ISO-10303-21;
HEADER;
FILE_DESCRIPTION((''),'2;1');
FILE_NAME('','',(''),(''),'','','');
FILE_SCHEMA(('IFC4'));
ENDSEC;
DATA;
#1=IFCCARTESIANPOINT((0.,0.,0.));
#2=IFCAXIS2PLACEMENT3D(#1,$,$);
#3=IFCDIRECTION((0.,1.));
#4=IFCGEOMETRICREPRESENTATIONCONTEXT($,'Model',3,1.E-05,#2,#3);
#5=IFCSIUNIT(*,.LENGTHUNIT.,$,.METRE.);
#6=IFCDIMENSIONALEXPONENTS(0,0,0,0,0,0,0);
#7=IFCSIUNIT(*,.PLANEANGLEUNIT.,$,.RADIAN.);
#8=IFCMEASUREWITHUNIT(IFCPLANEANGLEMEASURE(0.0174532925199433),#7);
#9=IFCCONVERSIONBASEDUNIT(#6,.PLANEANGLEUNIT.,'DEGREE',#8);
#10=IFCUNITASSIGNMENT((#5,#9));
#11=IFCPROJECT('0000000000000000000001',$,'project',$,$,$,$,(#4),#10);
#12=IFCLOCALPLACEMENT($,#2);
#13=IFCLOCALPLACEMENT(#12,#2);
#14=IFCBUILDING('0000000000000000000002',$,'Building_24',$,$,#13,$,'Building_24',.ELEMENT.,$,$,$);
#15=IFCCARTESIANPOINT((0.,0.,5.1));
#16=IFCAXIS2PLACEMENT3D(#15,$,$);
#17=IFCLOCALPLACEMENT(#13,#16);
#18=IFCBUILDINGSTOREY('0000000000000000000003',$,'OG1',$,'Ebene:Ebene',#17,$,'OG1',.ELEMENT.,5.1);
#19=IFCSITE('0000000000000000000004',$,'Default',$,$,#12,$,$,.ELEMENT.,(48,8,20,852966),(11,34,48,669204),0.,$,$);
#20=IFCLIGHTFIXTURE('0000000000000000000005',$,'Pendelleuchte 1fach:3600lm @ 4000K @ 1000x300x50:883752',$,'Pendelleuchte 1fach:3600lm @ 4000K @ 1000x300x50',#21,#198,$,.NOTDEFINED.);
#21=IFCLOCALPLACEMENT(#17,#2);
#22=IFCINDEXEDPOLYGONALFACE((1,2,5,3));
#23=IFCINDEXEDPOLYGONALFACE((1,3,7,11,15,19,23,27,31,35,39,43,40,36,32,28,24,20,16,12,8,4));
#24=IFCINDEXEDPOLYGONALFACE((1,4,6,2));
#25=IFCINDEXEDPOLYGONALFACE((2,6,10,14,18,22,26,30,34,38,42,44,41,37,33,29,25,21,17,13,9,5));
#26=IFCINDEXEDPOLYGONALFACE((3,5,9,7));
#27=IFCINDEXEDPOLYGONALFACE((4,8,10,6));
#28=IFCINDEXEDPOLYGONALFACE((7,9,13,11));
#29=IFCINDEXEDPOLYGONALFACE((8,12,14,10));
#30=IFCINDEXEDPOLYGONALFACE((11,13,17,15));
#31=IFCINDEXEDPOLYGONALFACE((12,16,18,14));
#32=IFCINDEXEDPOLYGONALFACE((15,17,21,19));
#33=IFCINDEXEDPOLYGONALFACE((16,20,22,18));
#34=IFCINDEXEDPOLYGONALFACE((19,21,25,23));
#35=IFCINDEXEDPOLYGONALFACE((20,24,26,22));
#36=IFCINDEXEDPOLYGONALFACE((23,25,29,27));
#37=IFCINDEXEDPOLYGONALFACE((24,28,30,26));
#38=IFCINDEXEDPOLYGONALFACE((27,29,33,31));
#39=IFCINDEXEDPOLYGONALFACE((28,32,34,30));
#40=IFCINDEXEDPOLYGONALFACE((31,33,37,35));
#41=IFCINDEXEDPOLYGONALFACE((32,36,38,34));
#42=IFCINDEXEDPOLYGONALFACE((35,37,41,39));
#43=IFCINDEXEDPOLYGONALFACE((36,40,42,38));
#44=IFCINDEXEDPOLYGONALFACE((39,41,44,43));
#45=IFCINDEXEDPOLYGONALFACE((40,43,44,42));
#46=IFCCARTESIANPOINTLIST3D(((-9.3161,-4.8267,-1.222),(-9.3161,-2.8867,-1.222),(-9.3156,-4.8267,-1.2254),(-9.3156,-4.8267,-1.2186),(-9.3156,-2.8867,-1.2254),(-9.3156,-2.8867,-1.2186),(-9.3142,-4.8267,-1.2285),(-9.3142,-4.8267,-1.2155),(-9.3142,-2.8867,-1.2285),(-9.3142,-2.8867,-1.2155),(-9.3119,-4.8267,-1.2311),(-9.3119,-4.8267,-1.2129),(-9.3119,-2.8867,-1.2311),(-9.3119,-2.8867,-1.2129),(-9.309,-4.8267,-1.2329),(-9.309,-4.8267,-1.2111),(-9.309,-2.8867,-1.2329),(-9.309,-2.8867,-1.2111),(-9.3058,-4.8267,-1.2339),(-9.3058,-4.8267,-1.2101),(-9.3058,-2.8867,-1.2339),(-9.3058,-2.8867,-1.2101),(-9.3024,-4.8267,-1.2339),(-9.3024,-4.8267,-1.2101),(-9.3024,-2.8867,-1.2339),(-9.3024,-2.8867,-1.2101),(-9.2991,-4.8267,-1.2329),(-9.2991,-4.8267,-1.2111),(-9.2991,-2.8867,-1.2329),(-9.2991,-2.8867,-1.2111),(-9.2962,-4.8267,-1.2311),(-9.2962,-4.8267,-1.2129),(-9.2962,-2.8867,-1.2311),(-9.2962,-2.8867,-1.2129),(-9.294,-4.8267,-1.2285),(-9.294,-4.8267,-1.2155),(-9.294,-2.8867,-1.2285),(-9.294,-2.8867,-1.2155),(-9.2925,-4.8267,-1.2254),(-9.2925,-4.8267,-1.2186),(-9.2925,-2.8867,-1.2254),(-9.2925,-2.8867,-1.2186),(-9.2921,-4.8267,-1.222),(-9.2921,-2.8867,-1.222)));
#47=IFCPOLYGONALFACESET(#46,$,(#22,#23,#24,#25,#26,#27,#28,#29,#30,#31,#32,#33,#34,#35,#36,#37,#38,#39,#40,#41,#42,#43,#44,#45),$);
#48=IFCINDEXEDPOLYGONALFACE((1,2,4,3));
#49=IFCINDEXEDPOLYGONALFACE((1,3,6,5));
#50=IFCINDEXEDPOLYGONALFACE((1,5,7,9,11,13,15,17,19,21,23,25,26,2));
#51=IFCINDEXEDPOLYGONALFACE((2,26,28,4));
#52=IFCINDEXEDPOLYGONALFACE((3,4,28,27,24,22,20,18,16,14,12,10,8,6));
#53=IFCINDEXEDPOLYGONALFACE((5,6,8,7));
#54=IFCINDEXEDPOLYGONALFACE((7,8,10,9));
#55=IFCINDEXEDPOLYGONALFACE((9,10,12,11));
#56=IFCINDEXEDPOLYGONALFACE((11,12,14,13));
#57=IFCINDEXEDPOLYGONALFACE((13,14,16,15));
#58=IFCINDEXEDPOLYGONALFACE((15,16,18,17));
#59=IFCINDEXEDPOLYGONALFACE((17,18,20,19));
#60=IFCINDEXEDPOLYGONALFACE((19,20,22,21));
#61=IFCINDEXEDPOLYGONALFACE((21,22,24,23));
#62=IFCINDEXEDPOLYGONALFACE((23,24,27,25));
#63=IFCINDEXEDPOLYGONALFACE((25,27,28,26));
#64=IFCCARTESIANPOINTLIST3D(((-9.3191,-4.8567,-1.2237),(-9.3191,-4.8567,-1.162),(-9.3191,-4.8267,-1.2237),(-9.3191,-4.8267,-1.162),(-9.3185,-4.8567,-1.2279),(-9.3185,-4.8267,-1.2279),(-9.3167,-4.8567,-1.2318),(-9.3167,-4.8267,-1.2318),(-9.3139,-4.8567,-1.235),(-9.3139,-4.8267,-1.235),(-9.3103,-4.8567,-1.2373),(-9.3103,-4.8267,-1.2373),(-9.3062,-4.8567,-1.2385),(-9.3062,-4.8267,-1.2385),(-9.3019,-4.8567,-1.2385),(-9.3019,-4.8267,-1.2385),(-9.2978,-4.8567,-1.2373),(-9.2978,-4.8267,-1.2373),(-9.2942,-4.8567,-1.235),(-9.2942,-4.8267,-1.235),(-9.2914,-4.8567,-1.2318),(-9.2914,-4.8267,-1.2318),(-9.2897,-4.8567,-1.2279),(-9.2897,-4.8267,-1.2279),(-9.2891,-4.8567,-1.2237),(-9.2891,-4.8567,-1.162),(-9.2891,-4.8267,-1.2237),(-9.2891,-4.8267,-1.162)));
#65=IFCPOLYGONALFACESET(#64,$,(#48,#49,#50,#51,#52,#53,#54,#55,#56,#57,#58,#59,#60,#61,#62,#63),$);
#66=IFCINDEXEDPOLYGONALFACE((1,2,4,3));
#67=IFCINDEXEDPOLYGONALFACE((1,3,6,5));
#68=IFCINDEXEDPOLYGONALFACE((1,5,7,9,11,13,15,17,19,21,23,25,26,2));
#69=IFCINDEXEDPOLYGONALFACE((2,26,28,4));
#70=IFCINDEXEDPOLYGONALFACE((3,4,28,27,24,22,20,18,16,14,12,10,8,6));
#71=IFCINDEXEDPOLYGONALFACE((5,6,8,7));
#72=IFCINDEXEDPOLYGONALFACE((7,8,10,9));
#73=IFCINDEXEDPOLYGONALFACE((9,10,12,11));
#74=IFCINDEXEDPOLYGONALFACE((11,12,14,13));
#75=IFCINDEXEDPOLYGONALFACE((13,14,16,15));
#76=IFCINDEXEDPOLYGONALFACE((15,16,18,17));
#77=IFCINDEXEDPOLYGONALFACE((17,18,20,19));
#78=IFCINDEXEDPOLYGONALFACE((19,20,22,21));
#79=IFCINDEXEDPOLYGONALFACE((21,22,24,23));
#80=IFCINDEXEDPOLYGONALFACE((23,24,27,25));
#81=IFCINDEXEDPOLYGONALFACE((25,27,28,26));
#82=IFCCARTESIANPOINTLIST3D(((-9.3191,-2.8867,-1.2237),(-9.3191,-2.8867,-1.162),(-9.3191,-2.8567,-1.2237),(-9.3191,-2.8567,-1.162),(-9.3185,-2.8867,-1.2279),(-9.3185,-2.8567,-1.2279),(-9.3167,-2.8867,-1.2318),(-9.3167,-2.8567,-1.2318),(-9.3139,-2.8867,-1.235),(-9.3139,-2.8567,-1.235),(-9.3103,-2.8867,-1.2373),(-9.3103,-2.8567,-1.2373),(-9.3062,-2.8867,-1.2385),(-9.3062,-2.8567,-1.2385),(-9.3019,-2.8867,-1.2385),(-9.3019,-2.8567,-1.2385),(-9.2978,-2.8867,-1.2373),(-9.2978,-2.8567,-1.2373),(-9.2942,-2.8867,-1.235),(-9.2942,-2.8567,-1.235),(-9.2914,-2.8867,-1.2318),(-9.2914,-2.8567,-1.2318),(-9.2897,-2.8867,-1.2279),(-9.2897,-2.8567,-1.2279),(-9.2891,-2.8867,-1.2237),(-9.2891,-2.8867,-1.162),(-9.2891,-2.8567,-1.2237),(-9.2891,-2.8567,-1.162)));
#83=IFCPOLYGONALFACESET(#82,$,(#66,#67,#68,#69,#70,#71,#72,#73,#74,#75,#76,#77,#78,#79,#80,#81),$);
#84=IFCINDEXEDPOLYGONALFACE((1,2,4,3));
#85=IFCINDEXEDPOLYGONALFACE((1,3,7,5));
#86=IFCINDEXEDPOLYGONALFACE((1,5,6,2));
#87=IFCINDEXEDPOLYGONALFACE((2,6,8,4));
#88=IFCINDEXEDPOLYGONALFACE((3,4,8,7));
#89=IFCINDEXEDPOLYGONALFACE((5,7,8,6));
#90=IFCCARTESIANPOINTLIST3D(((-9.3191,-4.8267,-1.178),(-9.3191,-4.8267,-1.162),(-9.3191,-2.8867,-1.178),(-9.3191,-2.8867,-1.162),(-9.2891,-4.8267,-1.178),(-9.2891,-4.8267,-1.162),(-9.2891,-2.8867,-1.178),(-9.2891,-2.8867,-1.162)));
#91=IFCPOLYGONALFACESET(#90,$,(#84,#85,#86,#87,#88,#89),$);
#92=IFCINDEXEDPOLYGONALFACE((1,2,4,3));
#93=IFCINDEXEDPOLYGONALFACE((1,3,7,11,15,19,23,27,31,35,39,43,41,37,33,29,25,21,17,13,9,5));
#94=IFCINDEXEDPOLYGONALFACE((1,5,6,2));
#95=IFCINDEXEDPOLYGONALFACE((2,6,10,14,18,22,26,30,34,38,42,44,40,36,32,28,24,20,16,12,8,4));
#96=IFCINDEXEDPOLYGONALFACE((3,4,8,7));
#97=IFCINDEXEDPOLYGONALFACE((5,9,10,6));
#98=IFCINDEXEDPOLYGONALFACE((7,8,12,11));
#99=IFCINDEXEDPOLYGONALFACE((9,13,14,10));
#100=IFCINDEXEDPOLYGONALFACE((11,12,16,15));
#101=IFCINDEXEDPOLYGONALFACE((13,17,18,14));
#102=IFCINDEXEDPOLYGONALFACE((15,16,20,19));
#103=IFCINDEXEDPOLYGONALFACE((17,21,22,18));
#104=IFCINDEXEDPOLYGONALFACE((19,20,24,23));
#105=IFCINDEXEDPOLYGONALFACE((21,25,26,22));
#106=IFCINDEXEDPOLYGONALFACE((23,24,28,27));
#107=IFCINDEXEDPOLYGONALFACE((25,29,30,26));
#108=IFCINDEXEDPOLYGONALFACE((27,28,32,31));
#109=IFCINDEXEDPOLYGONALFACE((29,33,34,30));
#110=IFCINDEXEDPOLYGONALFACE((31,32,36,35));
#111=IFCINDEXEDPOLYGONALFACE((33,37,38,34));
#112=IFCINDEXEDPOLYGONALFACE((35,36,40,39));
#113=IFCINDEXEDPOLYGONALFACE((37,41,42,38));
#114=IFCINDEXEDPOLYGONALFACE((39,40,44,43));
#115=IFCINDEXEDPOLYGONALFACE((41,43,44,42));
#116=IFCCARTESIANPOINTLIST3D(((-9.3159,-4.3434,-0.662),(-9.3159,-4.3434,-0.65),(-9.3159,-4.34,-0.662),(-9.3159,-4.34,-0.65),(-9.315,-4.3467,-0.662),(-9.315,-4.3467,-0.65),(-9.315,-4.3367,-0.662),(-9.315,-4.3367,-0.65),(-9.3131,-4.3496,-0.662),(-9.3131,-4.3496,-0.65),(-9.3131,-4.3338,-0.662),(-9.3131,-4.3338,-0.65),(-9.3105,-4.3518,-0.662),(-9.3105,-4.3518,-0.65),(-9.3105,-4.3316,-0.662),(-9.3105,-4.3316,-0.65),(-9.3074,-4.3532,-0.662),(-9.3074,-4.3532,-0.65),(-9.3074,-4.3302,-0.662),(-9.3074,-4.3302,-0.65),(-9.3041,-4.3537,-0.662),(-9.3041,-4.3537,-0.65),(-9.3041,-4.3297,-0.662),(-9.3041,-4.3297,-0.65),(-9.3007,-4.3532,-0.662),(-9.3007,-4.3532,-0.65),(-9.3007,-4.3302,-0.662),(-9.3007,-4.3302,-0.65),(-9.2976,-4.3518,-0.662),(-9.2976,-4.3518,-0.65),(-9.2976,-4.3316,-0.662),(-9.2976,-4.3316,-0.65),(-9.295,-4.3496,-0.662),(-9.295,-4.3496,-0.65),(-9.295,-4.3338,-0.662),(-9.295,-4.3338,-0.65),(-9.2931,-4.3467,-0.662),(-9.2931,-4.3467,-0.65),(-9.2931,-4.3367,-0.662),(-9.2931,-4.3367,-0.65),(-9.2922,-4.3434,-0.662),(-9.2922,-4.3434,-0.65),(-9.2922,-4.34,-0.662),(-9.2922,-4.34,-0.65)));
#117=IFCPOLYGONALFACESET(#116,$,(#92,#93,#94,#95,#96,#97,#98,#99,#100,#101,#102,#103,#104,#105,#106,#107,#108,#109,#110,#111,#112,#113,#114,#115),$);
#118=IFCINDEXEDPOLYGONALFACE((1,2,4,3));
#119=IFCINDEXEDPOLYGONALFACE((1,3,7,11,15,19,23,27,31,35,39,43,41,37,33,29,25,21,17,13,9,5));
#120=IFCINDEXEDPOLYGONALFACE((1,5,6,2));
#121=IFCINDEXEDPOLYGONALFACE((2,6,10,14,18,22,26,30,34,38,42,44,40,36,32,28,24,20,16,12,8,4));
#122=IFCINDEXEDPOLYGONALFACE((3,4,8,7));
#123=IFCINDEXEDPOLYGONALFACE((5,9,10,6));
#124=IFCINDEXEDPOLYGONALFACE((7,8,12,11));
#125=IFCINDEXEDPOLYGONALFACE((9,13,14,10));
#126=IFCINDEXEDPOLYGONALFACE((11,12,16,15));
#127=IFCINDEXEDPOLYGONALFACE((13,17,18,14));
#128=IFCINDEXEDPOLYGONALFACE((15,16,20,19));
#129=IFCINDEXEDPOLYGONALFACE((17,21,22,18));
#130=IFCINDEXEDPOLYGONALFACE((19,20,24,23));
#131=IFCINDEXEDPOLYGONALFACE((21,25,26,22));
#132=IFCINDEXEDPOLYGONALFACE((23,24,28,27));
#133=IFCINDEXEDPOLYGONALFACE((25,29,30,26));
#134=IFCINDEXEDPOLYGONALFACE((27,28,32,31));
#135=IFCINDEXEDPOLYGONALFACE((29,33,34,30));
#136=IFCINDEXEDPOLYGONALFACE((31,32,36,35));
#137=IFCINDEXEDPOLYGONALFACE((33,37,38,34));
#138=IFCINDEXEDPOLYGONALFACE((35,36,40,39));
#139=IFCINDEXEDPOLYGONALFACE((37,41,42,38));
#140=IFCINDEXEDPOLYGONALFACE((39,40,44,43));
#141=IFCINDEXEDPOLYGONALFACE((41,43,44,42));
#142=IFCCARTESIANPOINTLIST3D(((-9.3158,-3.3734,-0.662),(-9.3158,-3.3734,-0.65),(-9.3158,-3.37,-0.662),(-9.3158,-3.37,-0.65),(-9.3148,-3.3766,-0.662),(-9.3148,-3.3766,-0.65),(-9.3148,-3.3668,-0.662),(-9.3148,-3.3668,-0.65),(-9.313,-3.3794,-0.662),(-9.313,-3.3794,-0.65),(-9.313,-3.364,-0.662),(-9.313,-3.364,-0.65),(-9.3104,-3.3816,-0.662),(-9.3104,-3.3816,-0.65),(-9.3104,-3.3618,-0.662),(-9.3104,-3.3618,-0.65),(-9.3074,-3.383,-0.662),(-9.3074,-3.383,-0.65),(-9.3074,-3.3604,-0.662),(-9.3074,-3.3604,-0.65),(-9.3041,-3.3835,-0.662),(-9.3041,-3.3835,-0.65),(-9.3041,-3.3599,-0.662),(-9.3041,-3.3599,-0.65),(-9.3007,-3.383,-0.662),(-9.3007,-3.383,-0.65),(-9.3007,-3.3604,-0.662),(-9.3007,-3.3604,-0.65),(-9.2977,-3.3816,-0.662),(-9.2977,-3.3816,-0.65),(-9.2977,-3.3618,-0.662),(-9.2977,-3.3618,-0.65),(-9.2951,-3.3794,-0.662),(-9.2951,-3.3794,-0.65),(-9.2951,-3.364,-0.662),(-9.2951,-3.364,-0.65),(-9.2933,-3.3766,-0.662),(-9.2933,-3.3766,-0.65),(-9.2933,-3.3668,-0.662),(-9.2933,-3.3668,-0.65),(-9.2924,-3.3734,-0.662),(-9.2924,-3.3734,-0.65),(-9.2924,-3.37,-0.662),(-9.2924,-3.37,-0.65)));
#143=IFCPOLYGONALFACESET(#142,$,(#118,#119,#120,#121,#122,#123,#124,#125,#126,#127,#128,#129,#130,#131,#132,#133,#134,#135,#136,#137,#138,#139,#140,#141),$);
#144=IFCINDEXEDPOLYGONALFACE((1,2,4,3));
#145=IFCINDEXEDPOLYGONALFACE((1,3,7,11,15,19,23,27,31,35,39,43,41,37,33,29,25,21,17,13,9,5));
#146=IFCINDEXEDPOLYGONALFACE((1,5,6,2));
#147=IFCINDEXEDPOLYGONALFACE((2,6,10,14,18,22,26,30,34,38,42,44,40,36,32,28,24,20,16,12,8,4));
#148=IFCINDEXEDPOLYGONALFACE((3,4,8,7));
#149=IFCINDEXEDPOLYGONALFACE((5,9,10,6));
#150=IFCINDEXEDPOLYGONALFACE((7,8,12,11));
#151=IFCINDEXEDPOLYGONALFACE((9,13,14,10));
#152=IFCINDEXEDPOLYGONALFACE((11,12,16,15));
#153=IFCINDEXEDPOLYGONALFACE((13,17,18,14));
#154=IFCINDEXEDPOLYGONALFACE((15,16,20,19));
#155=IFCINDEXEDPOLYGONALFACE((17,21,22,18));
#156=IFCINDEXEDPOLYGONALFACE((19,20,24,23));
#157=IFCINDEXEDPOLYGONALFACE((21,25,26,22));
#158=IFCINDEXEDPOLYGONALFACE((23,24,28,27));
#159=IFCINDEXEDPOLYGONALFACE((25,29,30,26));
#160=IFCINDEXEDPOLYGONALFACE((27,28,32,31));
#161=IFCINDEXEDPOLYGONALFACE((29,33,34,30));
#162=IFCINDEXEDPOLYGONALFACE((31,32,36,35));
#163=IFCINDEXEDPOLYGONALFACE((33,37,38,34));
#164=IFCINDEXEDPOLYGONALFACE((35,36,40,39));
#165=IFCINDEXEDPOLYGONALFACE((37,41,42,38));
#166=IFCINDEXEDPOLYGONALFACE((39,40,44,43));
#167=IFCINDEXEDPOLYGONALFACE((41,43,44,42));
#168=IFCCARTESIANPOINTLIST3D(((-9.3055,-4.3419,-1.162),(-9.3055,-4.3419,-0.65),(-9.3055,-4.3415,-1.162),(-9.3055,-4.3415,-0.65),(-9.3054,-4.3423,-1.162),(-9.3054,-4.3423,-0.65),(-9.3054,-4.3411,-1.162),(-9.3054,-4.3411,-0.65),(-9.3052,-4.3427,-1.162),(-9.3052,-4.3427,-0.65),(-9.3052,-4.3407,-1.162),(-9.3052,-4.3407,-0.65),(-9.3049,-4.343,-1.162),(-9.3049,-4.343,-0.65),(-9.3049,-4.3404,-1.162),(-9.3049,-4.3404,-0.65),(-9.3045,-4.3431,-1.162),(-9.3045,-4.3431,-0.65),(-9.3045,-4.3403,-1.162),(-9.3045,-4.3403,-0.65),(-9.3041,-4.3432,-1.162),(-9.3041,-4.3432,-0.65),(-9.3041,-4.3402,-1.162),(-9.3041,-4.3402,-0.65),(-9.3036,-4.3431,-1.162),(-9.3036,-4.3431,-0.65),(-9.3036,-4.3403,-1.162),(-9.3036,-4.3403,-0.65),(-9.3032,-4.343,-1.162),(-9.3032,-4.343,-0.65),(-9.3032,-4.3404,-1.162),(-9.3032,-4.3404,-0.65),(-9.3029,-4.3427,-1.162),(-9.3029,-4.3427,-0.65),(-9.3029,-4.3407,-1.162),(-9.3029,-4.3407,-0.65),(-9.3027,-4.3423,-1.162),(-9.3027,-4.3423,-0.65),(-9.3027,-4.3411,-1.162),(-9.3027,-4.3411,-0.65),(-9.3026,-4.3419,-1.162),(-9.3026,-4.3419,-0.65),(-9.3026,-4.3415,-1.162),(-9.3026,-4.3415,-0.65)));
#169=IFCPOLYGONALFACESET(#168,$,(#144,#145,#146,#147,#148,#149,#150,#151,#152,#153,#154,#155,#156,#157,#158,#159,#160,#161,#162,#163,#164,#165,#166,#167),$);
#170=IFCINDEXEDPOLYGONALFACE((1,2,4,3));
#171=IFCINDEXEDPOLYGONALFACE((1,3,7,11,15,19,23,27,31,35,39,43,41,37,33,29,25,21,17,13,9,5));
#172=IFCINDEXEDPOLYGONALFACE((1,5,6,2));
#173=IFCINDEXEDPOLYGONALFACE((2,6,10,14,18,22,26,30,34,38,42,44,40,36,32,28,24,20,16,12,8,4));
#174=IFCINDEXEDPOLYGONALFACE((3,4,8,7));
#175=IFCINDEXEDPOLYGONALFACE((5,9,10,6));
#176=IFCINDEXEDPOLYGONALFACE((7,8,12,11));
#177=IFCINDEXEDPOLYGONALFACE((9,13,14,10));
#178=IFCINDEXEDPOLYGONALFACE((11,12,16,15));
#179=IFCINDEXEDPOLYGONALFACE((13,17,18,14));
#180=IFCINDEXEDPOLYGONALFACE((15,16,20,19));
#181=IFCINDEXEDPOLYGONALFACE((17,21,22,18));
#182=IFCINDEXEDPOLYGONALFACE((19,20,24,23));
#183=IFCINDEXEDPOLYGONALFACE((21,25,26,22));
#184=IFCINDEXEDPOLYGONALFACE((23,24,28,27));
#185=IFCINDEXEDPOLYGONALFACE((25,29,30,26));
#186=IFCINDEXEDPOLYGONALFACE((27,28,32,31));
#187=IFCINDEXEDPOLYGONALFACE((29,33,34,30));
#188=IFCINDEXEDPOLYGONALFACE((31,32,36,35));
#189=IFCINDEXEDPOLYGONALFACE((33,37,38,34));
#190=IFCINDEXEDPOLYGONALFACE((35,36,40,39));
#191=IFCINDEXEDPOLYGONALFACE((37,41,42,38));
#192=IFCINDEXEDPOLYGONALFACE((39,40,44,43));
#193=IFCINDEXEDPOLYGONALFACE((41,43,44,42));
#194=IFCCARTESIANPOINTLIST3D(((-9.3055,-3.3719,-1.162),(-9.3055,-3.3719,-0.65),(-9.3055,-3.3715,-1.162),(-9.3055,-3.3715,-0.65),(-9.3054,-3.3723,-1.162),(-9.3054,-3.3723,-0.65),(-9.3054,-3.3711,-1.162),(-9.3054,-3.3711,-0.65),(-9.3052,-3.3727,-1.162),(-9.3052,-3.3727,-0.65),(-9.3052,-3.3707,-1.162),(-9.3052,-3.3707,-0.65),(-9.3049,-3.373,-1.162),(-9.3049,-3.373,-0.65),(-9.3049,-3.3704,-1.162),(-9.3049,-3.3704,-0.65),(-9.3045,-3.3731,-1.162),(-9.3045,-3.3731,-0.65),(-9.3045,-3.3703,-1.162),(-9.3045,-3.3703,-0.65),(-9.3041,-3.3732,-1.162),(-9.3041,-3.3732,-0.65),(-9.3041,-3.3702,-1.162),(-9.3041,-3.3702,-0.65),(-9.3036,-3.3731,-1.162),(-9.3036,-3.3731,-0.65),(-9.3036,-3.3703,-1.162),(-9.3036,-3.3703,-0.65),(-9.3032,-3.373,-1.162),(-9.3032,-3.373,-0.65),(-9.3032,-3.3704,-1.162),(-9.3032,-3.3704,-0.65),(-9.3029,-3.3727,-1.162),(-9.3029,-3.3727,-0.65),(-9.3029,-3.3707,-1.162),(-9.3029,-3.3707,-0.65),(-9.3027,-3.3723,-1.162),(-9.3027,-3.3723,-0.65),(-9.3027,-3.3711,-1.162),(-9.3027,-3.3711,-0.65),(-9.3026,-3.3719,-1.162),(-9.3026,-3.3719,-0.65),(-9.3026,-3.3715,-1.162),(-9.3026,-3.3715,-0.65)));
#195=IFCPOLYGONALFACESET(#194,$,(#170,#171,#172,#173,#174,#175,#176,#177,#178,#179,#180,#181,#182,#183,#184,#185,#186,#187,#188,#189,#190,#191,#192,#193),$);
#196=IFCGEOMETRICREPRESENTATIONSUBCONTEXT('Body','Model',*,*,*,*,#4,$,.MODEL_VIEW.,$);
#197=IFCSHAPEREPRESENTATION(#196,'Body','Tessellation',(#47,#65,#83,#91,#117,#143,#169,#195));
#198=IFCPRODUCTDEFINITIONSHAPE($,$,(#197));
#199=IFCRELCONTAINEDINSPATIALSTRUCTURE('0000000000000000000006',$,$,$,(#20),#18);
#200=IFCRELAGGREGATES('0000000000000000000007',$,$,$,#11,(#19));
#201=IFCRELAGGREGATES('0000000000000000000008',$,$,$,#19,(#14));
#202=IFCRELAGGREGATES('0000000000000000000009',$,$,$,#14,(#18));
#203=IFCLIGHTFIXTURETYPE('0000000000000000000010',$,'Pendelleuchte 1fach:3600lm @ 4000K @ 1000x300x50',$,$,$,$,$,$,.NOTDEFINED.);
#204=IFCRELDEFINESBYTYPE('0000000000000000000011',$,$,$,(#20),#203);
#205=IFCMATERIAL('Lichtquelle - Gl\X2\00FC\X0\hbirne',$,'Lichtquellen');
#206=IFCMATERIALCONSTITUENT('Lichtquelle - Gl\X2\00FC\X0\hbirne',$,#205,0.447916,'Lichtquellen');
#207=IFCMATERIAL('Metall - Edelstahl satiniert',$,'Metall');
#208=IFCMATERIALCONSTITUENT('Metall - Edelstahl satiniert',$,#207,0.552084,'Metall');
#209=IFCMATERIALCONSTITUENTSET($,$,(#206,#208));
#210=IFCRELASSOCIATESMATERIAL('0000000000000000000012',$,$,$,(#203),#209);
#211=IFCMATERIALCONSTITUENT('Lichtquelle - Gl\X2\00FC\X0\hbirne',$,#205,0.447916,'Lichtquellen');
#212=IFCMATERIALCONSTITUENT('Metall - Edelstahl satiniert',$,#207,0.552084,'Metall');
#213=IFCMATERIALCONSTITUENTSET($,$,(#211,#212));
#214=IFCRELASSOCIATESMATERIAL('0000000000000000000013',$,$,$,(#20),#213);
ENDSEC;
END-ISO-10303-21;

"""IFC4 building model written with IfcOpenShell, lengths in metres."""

from ifc_helpers import new_model, entity, si_unit, converted_unit, direction, frame, origin, place, context, subcontext, project, spatial, line, arc, indexed_curve, outline, extrude, source, transform, mapped, material, constituent, constituent_set, type_object, type_shapes, element, save


model = new_model("IFC4")

# Units and contexts
model_context = context("Model", 3, precision=1e-05, world=origin(), true_north=direction((0.0, 1.0)))
body_context = subcontext(model_context, "Body", "Model", "MODEL_VIEW")
ifc_project = project(units=[si_unit("LENGTHUNIT", "METRE"), converted_unit("PLANEANGLEUNIT", "DEGREE", entity("IfcPlaneAngleMeasure", 0.0174532925199433), si_unit("PLANEANGLEUNIT", "RADIAN"), dimensions=[0, 0, 0, 0, 0, 0, 0])], contexts=[model_context])

# Site, building, storey
site_placement = place(None, origin())
site = spatial("IfcSite", under=ifc_project, at=site_placement, Name="Default", CompositionType="ELEMENT", RefLatitude=(48, 8, 20, 852966), RefLongitude=(11, 34, 48, 669204), RefElevation=0.0)
building_placement = place(site_placement, origin())
building = spatial("IfcBuilding", under=site, at=building_placement, Name="Building_24", LongName="Building_24", CompositionType="ELEMENT")
storey_placement = place(building_placement, frame((0.0, 0.0, 5.1)))
storey = spatial("IfcBuildingStorey", under=building, at=storey_placement, Name="OG1", ObjectType="Ebene:Ebene", LongName="OG1", CompositionType="ELEMENT", Elevation=5.1)

# Light fixture
ifc_material_1 = material(Name="Lichtquelle - Glühbirne", Category="Lichtquellen")
ifc_material_2 = material(Name="Metall - Edelstahl satiniert", Category="Metall")
ifc_constituent_1 = constituent(ifc_material_1, Name="Lichtquelle - Glühbirne", Category="Lichtquellen", fraction=0.447916)
ifc_constituent_2 = constituent(ifc_material_2, Name="Metall - Edelstahl satiniert", Category="Metall", fraction=0.552084)
ifc_constituent_set_1 = constituent_set(constituents=[ifc_constituent_1, ifc_constituent_2])
light_fixture_type_1 = type_object("IfcLightFixtureType", Name="Pendelleuchte 1fach:3600lm @ 4000K @ 1000x300x50", PredefinedType="NOTDEFINED", material=ifc_constituent_set_1)
shared_shape_1 = source(origin(), body_context, "Body", "SweptSolid", [
    extrude(outline(indexed_curve([(-0.012, 0.0), (0.0, -0.012), (0.012, 0.0), (0.0, 0.012)], segments=[arc(1, 2, 3), arc(3, 4, 1)], self_intersect=False)), frame((-0.97, 0.0, -0.572), z_axis=(1.0, 0.0, 0.0), x_axis=(0.0, 1.0, 0.0)), (0.0, 0.0, 1.0), 1.94),
    extrude(outline(indexed_curve([(-0.0308, -0.015), (0.0308, -0.015), (0.0308, 0.015), (-0.0308, 0.015), (-0.0458, 0.0)], segments=[line(1, 2, 3, 4), arc(4, 5, 1)], self_intersect=False)), frame((0.97, 0.0, -0.5428), z_axis=(1.0, 0.0, 0.0), x_axis=(0.0, 0.0, 1.0)), (0.0, 0.0, 1.0), 0.03),
    extrude(outline(indexed_curve([(-0.0308, -0.015), (0.0308, -0.015), (0.0308, 0.015), (-0.0308, 0.015), (-0.0458, 0.0)], segments=[line(1, 2, 3, 4), arc(4, 5, 1)], self_intersect=False)), frame((-1.0, 0.0, -0.5428), z_axis=(1.0, 0.0, 0.0), x_axis=(0.0, 0.0, 1.0)), (0.0, 0.0, 1.0), 0.03),
    extrude(outline(indexed_curve([(-0.97, -0.015), (0.97, -0.015), (0.97, 0.015), (-0.97, 0.015), (-0.97, -0.015)], self_intersect=False)), frame((0.0, 0.0, -0.528), z_axis=(0.0, 0.0, 1.0), x_axis=(-1.0, 0.0, 0.0)), (0.0, 0.0, 1.0), 0.016),
    extrude(outline(indexed_curve([(-0.012, 0.0), (0.0, -0.012), (0.012, 0.0), (0.0, 0.012)], segments=[arc(1, 2, 3), arc(3, 4, 1)], self_intersect=False)), frame((0.485, 0.0, -0.012)), (0.0, 0.0, 1.0), 0.012),
    extrude(outline(indexed_curve([(-0.0118, 0.0), (0.0, -0.0118), (0.0118, 0.0), (0.0, 0.0118)], segments=[arc(1, 2, 3), arc(3, 4, 1)], self_intersect=False)), frame((-0.485, 0.0, -0.012)), (0.0, 0.0, 1.0), 0.012),
    extrude(outline(indexed_curve([(-0.0015, 0.0), (0.0, -0.0015), (0.0015, 0.0), (0.0, 0.0015)], segments=[arc(1, 2, 3), arc(3, 4, 1)], self_intersect=False)), frame((0.485, 0.0, -0.512)), (0.0, 0.0, 1.0), 0.512),
    extrude(outline(indexed_curve([(-0.0015, 0.0), (0.0, -0.0015), (0.0015, 0.0), (0.0, 0.0015)], segments=[arc(1, 2, 3), arc(3, 4, 1)], self_intersect=False)), frame((-0.485, 0.0, -0.512)), (0.0, 0.0, 1.0), 0.512),
])
type_shapes(light_fixture_type_1, [shared_shape_1])
ifc_constituent_3 = constituent(ifc_material_1, Name="Lichtquelle - Glühbirne", Category="Lichtquellen", fraction=0.447916)
ifc_constituent_4 = constituent(ifc_material_2, Name="Metall - Edelstahl satiniert", Category="Metall", fraction=0.552084)
ifc_constituent_set_2 = constituent_set(constituents=[ifc_constituent_3, ifc_constituent_4])
light_fixture_1_placement = place(storey_placement, frame((-9.3041, -3.8567, -0.65), z_axis=(0.0, 0.0, 1.0), x_axis=(0.0, -1.0, 0.0)))
element("IfcLightFixture", 1, at=light_fixture_1_placement, inside=storey, type_object=light_fixture_type_1, material=ifc_constituent_set_2, Name="Pendelleuchte 1fach:3600lm @ 4000K @ 1000x300x50:883752", ObjectType="Pendelleuchte 1fach:3600lm @ 4000K @ 1000x300x50", PredefinedType="NOTDEFINED", context=body_context, shape_type="MappedRepresentation", body=[
    mapped(shared_shape_1, transform((0.0, 0.0, 0.0), scale=1.0)),
])

save(model, "model.ifc")
